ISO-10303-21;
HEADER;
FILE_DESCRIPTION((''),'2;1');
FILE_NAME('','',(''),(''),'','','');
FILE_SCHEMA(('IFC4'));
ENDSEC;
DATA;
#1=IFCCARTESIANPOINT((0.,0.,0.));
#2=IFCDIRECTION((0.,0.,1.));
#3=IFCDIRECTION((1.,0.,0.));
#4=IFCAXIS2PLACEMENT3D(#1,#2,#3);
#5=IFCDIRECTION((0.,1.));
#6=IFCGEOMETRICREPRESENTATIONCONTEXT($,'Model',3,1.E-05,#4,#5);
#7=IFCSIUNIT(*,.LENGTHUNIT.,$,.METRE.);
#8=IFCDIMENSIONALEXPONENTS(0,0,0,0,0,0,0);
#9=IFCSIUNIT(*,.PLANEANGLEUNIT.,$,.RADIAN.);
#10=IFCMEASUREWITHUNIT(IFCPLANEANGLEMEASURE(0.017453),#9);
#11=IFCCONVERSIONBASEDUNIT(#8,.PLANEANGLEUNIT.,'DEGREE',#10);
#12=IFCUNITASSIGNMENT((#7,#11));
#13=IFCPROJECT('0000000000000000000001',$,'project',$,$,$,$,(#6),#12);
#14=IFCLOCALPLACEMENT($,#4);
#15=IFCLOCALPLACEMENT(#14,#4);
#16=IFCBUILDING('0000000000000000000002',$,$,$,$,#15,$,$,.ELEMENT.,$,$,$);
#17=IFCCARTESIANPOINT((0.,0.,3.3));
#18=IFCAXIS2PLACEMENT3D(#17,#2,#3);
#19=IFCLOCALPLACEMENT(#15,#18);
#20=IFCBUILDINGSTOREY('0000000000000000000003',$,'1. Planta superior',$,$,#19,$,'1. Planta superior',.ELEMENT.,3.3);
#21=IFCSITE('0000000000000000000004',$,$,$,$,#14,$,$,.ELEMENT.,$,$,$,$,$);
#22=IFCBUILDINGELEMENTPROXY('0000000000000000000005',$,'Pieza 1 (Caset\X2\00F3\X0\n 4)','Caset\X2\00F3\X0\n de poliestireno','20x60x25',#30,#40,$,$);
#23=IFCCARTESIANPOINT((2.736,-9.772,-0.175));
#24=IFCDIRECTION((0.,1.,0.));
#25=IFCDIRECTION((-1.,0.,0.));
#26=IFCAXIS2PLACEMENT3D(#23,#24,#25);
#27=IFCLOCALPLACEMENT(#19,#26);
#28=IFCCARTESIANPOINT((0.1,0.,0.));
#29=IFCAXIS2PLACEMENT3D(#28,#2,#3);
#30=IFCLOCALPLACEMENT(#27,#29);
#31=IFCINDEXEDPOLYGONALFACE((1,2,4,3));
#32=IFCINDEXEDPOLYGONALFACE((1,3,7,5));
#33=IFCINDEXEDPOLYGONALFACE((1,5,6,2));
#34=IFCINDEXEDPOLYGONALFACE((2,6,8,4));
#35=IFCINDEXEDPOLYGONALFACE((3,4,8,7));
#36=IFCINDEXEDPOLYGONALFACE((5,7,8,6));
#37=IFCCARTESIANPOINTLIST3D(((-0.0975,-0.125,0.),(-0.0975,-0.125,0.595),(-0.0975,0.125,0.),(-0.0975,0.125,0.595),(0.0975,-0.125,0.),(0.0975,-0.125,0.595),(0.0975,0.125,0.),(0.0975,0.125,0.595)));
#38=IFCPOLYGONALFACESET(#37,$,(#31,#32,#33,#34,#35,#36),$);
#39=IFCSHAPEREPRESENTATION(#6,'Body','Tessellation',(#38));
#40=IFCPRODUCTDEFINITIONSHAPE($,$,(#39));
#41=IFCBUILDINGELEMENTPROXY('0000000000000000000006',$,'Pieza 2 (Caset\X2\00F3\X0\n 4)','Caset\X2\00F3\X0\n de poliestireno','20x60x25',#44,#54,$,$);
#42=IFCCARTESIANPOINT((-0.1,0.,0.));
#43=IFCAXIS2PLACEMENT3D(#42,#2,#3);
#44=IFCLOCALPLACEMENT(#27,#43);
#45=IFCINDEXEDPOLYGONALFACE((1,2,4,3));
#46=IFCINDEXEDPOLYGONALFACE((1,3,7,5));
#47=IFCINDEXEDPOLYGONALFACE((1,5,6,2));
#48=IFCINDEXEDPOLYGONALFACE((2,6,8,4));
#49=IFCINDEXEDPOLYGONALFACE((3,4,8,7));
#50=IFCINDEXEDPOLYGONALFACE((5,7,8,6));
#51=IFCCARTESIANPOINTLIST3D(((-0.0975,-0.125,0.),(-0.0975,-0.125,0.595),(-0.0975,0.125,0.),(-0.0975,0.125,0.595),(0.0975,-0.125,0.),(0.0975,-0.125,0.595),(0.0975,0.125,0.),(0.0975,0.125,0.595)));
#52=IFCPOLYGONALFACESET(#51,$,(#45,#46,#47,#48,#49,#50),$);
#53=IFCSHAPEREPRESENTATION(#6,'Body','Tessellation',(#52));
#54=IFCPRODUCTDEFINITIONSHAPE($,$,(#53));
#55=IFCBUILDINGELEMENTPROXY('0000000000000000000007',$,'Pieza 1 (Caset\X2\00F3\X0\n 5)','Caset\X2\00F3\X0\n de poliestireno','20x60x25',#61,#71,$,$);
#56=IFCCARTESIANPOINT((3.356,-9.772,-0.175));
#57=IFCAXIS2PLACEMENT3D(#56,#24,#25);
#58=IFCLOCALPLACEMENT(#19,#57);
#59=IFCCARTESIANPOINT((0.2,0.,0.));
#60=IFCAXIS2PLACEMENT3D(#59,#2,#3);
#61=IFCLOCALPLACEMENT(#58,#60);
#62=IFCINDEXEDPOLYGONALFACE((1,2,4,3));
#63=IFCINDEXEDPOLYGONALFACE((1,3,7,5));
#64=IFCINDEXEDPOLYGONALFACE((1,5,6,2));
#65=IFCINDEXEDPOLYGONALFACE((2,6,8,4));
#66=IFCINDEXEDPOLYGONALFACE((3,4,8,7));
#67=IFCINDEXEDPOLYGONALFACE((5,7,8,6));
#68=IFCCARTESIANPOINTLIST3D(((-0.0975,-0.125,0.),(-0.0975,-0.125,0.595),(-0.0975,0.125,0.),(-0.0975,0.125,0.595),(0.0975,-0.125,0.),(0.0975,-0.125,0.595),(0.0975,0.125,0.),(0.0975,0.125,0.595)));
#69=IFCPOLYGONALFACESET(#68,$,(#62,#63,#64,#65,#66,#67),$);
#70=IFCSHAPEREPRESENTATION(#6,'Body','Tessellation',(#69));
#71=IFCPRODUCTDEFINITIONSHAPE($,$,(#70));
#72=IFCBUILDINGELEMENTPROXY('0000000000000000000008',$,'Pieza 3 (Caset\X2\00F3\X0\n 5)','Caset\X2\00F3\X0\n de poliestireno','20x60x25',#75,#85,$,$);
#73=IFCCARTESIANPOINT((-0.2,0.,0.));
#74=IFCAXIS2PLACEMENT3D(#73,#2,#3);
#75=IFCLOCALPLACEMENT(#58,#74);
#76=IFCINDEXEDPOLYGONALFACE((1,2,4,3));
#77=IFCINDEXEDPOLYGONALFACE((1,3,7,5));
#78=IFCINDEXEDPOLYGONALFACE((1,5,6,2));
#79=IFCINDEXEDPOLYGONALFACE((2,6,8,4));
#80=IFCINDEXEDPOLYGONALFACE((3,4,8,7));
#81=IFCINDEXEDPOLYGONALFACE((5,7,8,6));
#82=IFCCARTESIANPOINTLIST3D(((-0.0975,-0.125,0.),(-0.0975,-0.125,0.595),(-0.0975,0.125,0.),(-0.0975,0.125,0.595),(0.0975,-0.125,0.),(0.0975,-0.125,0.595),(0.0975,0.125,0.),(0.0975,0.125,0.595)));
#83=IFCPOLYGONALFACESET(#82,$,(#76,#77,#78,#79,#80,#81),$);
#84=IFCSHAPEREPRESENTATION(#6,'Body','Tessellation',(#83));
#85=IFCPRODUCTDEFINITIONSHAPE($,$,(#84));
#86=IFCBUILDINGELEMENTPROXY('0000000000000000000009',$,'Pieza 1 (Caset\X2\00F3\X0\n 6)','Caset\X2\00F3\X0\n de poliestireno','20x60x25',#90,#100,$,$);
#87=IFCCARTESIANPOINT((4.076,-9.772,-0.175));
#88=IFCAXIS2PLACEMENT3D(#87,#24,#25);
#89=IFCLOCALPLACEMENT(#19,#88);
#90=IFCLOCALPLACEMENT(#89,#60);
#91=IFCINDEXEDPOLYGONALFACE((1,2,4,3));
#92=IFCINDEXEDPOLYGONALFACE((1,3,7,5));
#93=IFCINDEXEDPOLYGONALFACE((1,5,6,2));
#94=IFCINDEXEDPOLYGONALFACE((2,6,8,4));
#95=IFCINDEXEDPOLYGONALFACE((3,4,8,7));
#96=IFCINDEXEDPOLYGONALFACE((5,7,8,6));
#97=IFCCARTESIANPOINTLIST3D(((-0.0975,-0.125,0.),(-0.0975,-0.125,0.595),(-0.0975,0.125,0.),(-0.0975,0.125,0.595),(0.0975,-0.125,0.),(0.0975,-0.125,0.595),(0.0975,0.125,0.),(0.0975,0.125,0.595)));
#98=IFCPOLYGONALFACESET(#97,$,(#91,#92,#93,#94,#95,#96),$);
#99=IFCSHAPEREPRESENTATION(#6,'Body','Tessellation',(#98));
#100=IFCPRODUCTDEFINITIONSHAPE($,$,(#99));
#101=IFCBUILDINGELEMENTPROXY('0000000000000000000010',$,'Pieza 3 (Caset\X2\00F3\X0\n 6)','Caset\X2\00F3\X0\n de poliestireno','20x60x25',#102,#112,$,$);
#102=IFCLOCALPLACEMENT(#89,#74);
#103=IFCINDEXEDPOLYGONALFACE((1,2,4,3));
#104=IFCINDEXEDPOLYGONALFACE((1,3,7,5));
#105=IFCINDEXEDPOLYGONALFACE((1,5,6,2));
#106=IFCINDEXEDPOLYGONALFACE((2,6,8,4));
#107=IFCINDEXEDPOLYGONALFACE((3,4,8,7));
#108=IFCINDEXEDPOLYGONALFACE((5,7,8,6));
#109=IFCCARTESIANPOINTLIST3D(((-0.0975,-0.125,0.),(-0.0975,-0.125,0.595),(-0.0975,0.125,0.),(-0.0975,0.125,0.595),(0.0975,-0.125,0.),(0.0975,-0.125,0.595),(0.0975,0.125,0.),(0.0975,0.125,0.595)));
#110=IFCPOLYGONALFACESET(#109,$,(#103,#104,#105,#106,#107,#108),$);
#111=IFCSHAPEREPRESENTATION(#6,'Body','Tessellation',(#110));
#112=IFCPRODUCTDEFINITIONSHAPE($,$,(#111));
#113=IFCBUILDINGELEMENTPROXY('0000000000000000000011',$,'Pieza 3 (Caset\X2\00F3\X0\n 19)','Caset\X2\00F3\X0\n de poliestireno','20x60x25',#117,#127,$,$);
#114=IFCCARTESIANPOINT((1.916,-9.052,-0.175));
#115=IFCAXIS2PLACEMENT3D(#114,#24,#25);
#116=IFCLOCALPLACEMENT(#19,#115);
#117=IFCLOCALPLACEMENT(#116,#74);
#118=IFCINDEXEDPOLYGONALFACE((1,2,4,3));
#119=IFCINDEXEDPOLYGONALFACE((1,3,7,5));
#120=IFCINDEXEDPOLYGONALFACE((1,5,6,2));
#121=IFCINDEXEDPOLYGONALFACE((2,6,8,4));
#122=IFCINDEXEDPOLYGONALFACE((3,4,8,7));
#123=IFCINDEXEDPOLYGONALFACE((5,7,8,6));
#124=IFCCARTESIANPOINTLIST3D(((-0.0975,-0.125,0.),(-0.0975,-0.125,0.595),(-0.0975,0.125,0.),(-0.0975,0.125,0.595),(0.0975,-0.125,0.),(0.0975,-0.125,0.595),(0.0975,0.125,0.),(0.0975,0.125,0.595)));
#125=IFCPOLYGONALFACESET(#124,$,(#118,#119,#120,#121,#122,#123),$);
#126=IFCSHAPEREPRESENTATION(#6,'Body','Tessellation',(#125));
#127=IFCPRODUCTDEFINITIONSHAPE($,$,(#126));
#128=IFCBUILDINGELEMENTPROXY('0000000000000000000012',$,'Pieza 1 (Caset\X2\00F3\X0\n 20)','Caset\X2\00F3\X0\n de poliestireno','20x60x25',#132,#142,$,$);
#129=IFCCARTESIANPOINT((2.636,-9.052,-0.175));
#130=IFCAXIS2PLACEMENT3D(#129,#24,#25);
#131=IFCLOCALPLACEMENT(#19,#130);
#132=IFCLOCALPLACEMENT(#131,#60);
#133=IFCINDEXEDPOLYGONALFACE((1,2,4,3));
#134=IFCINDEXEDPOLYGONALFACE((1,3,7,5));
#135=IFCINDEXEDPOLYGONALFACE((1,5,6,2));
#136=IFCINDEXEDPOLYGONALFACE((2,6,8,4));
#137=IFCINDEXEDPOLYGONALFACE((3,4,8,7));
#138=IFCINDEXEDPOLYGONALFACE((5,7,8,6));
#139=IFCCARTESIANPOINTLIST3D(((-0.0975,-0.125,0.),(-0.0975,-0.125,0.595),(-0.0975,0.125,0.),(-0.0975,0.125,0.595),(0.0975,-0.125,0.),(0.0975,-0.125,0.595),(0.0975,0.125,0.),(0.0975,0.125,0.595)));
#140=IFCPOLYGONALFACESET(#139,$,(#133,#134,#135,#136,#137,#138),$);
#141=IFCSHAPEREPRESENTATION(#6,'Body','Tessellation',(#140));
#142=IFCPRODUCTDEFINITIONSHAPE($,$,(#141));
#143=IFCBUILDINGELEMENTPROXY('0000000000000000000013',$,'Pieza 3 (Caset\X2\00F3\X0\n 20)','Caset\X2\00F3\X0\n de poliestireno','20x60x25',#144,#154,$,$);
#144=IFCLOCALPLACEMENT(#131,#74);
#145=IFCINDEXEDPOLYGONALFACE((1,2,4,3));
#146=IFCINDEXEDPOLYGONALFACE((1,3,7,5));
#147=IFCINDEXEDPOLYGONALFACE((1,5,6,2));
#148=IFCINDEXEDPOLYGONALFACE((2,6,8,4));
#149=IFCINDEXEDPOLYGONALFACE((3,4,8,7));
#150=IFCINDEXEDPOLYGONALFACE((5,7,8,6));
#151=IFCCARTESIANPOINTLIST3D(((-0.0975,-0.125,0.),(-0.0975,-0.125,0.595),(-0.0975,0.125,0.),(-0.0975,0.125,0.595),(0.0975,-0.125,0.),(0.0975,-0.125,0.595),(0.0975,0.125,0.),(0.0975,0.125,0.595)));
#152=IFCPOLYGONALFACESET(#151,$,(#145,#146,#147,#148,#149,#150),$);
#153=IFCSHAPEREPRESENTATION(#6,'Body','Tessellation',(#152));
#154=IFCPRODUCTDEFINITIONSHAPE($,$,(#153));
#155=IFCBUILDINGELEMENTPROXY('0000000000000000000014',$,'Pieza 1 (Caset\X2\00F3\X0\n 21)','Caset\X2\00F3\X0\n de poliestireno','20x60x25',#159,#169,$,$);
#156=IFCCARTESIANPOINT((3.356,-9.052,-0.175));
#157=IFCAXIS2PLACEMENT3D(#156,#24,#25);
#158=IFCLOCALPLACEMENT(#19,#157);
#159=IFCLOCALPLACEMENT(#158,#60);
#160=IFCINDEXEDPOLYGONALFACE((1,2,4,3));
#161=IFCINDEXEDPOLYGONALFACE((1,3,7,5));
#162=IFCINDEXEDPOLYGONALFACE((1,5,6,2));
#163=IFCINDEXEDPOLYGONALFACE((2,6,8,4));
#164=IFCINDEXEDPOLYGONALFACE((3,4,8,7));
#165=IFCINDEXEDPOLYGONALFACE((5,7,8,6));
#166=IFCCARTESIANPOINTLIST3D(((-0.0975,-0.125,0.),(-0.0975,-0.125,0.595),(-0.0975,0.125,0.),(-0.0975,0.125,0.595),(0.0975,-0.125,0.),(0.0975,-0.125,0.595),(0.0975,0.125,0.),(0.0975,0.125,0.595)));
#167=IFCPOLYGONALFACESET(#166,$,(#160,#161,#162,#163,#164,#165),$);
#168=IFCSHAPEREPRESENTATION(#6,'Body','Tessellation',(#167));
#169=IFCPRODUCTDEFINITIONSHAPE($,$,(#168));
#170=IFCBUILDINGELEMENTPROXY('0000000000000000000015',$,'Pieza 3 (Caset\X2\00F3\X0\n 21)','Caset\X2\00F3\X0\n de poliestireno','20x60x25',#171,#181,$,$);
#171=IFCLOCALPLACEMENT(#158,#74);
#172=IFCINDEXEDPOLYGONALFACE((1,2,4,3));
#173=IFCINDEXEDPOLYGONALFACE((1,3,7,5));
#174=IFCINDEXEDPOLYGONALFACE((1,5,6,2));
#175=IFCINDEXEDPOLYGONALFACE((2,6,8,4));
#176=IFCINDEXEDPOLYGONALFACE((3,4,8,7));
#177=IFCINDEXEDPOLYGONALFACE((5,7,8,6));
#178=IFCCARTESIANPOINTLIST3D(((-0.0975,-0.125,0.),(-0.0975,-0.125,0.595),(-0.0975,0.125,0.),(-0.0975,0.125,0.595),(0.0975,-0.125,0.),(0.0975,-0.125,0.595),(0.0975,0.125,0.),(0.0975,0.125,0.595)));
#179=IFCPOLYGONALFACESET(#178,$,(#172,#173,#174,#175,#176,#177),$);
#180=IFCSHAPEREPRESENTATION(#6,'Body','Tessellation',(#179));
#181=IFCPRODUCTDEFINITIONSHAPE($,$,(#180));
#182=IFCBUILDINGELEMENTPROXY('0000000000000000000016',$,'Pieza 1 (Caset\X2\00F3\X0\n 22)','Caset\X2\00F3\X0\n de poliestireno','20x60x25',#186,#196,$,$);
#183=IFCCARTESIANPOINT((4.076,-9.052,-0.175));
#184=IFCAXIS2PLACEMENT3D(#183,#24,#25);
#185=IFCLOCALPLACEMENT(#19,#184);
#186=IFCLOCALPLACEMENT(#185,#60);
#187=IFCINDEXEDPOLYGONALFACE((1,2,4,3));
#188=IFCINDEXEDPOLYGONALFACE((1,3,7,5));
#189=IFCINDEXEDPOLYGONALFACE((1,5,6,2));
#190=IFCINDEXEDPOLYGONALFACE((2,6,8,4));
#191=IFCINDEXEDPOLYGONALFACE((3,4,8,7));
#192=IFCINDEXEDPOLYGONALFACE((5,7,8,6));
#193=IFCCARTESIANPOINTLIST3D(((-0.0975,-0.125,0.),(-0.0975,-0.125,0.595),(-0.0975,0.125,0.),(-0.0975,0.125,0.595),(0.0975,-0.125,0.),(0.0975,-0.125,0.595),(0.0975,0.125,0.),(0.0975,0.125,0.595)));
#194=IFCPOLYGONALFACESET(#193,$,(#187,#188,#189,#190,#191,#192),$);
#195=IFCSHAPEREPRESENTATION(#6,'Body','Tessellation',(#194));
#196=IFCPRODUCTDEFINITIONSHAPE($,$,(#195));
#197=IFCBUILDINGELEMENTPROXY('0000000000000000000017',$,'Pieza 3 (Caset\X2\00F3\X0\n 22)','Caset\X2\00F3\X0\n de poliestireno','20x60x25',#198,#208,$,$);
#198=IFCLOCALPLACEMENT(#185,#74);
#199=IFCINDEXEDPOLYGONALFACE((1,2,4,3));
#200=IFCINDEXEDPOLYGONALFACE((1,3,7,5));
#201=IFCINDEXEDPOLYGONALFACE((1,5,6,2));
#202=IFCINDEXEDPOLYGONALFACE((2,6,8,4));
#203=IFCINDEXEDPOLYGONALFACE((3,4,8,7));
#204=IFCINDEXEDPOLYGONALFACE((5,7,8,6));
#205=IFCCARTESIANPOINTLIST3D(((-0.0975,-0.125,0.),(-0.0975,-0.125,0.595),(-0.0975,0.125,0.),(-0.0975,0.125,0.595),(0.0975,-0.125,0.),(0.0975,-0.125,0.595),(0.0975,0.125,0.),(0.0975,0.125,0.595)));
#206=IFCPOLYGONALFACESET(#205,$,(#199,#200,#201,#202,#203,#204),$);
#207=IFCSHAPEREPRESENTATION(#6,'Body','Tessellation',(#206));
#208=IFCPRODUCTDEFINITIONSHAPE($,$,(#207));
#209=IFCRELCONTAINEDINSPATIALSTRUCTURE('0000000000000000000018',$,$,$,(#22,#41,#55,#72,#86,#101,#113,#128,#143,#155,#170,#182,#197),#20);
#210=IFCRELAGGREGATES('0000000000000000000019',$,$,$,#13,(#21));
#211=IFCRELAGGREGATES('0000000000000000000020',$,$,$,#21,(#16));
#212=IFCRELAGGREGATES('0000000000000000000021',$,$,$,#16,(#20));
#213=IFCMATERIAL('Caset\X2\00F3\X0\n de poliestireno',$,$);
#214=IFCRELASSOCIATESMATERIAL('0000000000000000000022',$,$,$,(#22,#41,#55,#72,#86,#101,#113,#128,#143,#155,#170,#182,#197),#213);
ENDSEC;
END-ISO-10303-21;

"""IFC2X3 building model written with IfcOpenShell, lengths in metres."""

from ifc_helpers import new_model, entity, si_unit, converted_unit, direction, frame, origin_with_axes, origin_2d_with_axis, place, context, project, spatial, rectangle, extrude, source, transform, mapped, material, element, save


model = new_model("IFC2X3")

# Units and contexts
model_context = context("Model", 3, precision=1e-05, world=origin_with_axes(), true_north=direction((0.0, 1.0)))
ifc_project = project(units=[si_unit("LENGTHUNIT", "METRE"), converted_unit("PLANEANGLEUNIT", "DEGREE", entity("IfcPlaneAngleMeasure", 0.017453), si_unit("PLANEANGLEUNIT", "RADIAN"), dimensions=[0, 0, 0, 0, 0, 0, 0])], contexts=[model_context])

# Site, building, storey
site_placement = place(None, origin_with_axes())
site = spatial("IfcSite", under=ifc_project, at=site_placement, CompositionType="ELEMENT")
building_placement = place(site_placement, origin_with_axes())
building = spatial("IfcBuilding", under=site, at=building_placement, CompositionType="ELEMENT")
storey_placement = place(building_placement, frame((0.0, 0.0, 3.3), z_axis=(0.0, 0.0, 1.0), x_axis=(1.0, 0.0, 0.0)))
storey = spatial("IfcBuildingStorey", under=building, at=storey_placement, Name="1. Planta superior", LongName="1. Planta superior", CompositionType="ELEMENT", Elevation=3.3)

# Building element proxies
ifc_material = material(Name="Casetón de poliestireno")
shared_shape = source(origin_with_axes(), model_context, "Body", "SweptSolid", [
    extrude(rectangle(XDim=0.195, YDim=0.25, at=origin_2d_with_axis()), origin_with_axes(), (0.0, 0.0, 1.0), 0.595),
])
placement_1 = place(storey_placement, frame((2.736, -9.772, -0.175), z_axis=(0.0, 1.0, 0.0), x_axis=(-1.0, 0.0, 0.0)))
for number, where, z_axis, x_axis, name in (
    (1, (0.1, 0.0, 0.0), (0.0, 0.0, 1.0), (1.0, 0.0, 0.0), "Pieza 1 (Casetón 4)"),
    (2, (-0.1, 0.0, 0.0), (0.0, 0.0, 1.0), (1.0, 0.0, 0.0), "Pieza 2 (Casetón 4)"),
):
    element("IfcBuildingElementProxy", number, at=place(placement_1, frame(where, z_axis=z_axis, x_axis=x_axis)), inside=storey, material=ifc_material, Name=name, Description="Casetón de poliestireno", ObjectType="20x60x25", context=model_context, shape_type="MappedRepresentation", body=[
        mapped(shared_shape, transform((0.0, 0.0, 0.0), x_axis=(1.0, 0.0, 0.0), y_axis=(0.0, 1.0, 0.0), z_axis=(0.0, 0.0, 1.0))),
    ])
placement_2 = place(storey_placement, frame((3.356, -9.772, -0.175), z_axis=(0.0, 1.0, 0.0), x_axis=(-1.0, 0.0, 0.0)))
for number, where, z_axis, x_axis, name in (
    (3, (0.2, 0.0, 0.0), (0.0, 0.0, 1.0), (1.0, 0.0, 0.0), "Pieza 1 (Casetón 5)"),
    (4, (-0.2, 0.0, 0.0), (0.0, 0.0, 1.0), (1.0, 0.0, 0.0), "Pieza 3 (Casetón 5)"),
):
    element("IfcBuildingElementProxy", number, at=place(placement_2, frame(where, z_axis=z_axis, x_axis=x_axis)), inside=storey, material=ifc_material, Name=name, Description="Casetón de poliestireno", ObjectType="20x60x25", context=model_context, shape_type="MappedRepresentation", body=[
        mapped(shared_shape, transform((0.0, 0.0, 0.0), x_axis=(1.0, 0.0, 0.0), y_axis=(0.0, 1.0, 0.0), z_axis=(0.0, 0.0, 1.0))),
    ])
placement_3 = place(storey_placement, frame((4.076, -9.772, -0.175), z_axis=(0.0, 1.0, 0.0), x_axis=(-1.0, 0.0, 0.0)))
for number, where, z_axis, x_axis, name in (
    (5, (0.2, 0.0, 0.0), (0.0, 0.0, 1.0), (1.0, 0.0, 0.0), "Pieza 1 (Casetón 6)"),
    (6, (-0.2, 0.0, 0.0), (0.0, 0.0, 1.0), (1.0, 0.0, 0.0), "Pieza 3 (Casetón 6)"),
):
    element("IfcBuildingElementProxy", number, at=place(placement_3, frame(where, z_axis=z_axis, x_axis=x_axis)), inside=storey, material=ifc_material, Name=name, Description="Casetón de poliestireno", ObjectType="20x60x25", context=model_context, shape_type="MappedRepresentation", body=[
        mapped(shared_shape, transform((0.0, 0.0, 0.0), x_axis=(1.0, 0.0, 0.0), y_axis=(0.0, 1.0, 0.0), z_axis=(0.0, 0.0, 1.0))),
    ])
placement_4 = place(storey_placement, frame((1.916, -9.052, -0.175), z_axis=(0.0, 1.0, 0.0), x_axis=(-1.0, 0.0, 0.0)))
for number, where, z_axis, x_axis, name in (
    (7, (-0.2, 0.0, 0.0), (0.0, 0.0, 1.0), (1.0, 0.0, 0.0), "Pieza 3 (Casetón 19)"),
):
    element("IfcBuildingElementProxy", number, at=place(placement_4, frame(where, z_axis=z_axis, x_axis=x_axis)), inside=storey, material=ifc_material, Name=name, Description="Casetón de poliestireno", ObjectType="20x60x25", context=model_context, shape_type="MappedRepresentation", body=[
        mapped(shared_shape, transform((0.0, 0.0, 0.0), x_axis=(1.0, 0.0, 0.0), y_axis=(0.0, 1.0, 0.0), z_axis=(0.0, 0.0, 1.0))),
    ])
placement_5 = place(storey_placement, frame((2.636, -9.052, -0.175), z_axis=(0.0, 1.0, 0.0), x_axis=(-1.0, 0.0, 0.0)))
for number, where, z_axis, x_axis, name in (
    (8, (0.2, 0.0, 0.0), (0.0, 0.0, 1.0), (1.0, 0.0, 0.0), "Pieza 1 (Casetón 20)"),
    (9, (-0.2, 0.0, 0.0), (0.0, 0.0, 1.0), (1.0, 0.0, 0.0), "Pieza 3 (Casetón 20)"),
):
    element("IfcBuildingElementProxy", number, at=place(placement_5, frame(where, z_axis=z_axis, x_axis=x_axis)), inside=storey, material=ifc_material, Name=name, Description="Casetón de poliestireno", ObjectType="20x60x25", context=model_context, shape_type="MappedRepresentation", body=[
        mapped(shared_shape, transform((0.0, 0.0, 0.0), x_axis=(1.0, 0.0, 0.0), y_axis=(0.0, 1.0, 0.0), z_axis=(0.0, 0.0, 1.0))),
    ])
placement_6 = place(storey_placement, frame((3.356, -9.052, -0.175), z_axis=(0.0, 1.0, 0.0), x_axis=(-1.0, 0.0, 0.0)))
for number, where, z_axis, x_axis, name in (
    (10, (0.2, 0.0, 0.0), (0.0, 0.0, 1.0), (1.0, 0.0, 0.0), "Pieza 1 (Casetón 21)"),
    (11, (-0.2, 0.0, 0.0), (0.0, 0.0, 1.0), (1.0, 0.0, 0.0), "Pieza 3 (Casetón 21)"),
):
    element("IfcBuildingElementProxy", number, at=place(placement_6, frame(where, z_axis=z_axis, x_axis=x_axis)), inside=storey, material=ifc_material, Name=name, Description="Casetón de poliestireno", ObjectType="20x60x25", context=model_context, shape_type="MappedRepresentation", body=[
        mapped(shared_shape, transform((0.0, 0.0, 0.0), x_axis=(1.0, 0.0, 0.0), y_axis=(0.0, 1.0, 0.0), z_axis=(0.0, 0.0, 1.0))),
    ])
placement_7 = place(storey_placement, frame((4.076, -9.052, -0.175), z_axis=(0.0, 1.0, 0.0), x_axis=(-1.0, 0.0, 0.0)))
for number, where, z_axis, x_axis, name in (
    (12, (0.2, 0.0, 0.0), (0.0, 0.0, 1.0), (1.0, 0.0, 0.0), "Pieza 1 (Casetón 22)"),
    (13, (-0.2, 0.0, 0.0), (0.0, 0.0, 1.0), (1.0, 0.0, 0.0), "Pieza 3 (Casetón 22)"),
):
    element("IfcBuildingElementProxy", number, at=place(placement_7, frame(where, z_axis=z_axis, x_axis=x_axis)), inside=storey, material=ifc_material, Name=name, Description="Casetón de poliestireno", ObjectType="20x60x25", context=model_context, shape_type="MappedRepresentation", body=[
        mapped(shared_shape, transform((0.0, 0.0, 0.0), x_axis=(1.0, 0.0, 0.0), y_axis=(0.0, 1.0, 0.0), z_axis=(0.0, 0.0, 1.0))),
    ])

save(model, "model.ifc")
